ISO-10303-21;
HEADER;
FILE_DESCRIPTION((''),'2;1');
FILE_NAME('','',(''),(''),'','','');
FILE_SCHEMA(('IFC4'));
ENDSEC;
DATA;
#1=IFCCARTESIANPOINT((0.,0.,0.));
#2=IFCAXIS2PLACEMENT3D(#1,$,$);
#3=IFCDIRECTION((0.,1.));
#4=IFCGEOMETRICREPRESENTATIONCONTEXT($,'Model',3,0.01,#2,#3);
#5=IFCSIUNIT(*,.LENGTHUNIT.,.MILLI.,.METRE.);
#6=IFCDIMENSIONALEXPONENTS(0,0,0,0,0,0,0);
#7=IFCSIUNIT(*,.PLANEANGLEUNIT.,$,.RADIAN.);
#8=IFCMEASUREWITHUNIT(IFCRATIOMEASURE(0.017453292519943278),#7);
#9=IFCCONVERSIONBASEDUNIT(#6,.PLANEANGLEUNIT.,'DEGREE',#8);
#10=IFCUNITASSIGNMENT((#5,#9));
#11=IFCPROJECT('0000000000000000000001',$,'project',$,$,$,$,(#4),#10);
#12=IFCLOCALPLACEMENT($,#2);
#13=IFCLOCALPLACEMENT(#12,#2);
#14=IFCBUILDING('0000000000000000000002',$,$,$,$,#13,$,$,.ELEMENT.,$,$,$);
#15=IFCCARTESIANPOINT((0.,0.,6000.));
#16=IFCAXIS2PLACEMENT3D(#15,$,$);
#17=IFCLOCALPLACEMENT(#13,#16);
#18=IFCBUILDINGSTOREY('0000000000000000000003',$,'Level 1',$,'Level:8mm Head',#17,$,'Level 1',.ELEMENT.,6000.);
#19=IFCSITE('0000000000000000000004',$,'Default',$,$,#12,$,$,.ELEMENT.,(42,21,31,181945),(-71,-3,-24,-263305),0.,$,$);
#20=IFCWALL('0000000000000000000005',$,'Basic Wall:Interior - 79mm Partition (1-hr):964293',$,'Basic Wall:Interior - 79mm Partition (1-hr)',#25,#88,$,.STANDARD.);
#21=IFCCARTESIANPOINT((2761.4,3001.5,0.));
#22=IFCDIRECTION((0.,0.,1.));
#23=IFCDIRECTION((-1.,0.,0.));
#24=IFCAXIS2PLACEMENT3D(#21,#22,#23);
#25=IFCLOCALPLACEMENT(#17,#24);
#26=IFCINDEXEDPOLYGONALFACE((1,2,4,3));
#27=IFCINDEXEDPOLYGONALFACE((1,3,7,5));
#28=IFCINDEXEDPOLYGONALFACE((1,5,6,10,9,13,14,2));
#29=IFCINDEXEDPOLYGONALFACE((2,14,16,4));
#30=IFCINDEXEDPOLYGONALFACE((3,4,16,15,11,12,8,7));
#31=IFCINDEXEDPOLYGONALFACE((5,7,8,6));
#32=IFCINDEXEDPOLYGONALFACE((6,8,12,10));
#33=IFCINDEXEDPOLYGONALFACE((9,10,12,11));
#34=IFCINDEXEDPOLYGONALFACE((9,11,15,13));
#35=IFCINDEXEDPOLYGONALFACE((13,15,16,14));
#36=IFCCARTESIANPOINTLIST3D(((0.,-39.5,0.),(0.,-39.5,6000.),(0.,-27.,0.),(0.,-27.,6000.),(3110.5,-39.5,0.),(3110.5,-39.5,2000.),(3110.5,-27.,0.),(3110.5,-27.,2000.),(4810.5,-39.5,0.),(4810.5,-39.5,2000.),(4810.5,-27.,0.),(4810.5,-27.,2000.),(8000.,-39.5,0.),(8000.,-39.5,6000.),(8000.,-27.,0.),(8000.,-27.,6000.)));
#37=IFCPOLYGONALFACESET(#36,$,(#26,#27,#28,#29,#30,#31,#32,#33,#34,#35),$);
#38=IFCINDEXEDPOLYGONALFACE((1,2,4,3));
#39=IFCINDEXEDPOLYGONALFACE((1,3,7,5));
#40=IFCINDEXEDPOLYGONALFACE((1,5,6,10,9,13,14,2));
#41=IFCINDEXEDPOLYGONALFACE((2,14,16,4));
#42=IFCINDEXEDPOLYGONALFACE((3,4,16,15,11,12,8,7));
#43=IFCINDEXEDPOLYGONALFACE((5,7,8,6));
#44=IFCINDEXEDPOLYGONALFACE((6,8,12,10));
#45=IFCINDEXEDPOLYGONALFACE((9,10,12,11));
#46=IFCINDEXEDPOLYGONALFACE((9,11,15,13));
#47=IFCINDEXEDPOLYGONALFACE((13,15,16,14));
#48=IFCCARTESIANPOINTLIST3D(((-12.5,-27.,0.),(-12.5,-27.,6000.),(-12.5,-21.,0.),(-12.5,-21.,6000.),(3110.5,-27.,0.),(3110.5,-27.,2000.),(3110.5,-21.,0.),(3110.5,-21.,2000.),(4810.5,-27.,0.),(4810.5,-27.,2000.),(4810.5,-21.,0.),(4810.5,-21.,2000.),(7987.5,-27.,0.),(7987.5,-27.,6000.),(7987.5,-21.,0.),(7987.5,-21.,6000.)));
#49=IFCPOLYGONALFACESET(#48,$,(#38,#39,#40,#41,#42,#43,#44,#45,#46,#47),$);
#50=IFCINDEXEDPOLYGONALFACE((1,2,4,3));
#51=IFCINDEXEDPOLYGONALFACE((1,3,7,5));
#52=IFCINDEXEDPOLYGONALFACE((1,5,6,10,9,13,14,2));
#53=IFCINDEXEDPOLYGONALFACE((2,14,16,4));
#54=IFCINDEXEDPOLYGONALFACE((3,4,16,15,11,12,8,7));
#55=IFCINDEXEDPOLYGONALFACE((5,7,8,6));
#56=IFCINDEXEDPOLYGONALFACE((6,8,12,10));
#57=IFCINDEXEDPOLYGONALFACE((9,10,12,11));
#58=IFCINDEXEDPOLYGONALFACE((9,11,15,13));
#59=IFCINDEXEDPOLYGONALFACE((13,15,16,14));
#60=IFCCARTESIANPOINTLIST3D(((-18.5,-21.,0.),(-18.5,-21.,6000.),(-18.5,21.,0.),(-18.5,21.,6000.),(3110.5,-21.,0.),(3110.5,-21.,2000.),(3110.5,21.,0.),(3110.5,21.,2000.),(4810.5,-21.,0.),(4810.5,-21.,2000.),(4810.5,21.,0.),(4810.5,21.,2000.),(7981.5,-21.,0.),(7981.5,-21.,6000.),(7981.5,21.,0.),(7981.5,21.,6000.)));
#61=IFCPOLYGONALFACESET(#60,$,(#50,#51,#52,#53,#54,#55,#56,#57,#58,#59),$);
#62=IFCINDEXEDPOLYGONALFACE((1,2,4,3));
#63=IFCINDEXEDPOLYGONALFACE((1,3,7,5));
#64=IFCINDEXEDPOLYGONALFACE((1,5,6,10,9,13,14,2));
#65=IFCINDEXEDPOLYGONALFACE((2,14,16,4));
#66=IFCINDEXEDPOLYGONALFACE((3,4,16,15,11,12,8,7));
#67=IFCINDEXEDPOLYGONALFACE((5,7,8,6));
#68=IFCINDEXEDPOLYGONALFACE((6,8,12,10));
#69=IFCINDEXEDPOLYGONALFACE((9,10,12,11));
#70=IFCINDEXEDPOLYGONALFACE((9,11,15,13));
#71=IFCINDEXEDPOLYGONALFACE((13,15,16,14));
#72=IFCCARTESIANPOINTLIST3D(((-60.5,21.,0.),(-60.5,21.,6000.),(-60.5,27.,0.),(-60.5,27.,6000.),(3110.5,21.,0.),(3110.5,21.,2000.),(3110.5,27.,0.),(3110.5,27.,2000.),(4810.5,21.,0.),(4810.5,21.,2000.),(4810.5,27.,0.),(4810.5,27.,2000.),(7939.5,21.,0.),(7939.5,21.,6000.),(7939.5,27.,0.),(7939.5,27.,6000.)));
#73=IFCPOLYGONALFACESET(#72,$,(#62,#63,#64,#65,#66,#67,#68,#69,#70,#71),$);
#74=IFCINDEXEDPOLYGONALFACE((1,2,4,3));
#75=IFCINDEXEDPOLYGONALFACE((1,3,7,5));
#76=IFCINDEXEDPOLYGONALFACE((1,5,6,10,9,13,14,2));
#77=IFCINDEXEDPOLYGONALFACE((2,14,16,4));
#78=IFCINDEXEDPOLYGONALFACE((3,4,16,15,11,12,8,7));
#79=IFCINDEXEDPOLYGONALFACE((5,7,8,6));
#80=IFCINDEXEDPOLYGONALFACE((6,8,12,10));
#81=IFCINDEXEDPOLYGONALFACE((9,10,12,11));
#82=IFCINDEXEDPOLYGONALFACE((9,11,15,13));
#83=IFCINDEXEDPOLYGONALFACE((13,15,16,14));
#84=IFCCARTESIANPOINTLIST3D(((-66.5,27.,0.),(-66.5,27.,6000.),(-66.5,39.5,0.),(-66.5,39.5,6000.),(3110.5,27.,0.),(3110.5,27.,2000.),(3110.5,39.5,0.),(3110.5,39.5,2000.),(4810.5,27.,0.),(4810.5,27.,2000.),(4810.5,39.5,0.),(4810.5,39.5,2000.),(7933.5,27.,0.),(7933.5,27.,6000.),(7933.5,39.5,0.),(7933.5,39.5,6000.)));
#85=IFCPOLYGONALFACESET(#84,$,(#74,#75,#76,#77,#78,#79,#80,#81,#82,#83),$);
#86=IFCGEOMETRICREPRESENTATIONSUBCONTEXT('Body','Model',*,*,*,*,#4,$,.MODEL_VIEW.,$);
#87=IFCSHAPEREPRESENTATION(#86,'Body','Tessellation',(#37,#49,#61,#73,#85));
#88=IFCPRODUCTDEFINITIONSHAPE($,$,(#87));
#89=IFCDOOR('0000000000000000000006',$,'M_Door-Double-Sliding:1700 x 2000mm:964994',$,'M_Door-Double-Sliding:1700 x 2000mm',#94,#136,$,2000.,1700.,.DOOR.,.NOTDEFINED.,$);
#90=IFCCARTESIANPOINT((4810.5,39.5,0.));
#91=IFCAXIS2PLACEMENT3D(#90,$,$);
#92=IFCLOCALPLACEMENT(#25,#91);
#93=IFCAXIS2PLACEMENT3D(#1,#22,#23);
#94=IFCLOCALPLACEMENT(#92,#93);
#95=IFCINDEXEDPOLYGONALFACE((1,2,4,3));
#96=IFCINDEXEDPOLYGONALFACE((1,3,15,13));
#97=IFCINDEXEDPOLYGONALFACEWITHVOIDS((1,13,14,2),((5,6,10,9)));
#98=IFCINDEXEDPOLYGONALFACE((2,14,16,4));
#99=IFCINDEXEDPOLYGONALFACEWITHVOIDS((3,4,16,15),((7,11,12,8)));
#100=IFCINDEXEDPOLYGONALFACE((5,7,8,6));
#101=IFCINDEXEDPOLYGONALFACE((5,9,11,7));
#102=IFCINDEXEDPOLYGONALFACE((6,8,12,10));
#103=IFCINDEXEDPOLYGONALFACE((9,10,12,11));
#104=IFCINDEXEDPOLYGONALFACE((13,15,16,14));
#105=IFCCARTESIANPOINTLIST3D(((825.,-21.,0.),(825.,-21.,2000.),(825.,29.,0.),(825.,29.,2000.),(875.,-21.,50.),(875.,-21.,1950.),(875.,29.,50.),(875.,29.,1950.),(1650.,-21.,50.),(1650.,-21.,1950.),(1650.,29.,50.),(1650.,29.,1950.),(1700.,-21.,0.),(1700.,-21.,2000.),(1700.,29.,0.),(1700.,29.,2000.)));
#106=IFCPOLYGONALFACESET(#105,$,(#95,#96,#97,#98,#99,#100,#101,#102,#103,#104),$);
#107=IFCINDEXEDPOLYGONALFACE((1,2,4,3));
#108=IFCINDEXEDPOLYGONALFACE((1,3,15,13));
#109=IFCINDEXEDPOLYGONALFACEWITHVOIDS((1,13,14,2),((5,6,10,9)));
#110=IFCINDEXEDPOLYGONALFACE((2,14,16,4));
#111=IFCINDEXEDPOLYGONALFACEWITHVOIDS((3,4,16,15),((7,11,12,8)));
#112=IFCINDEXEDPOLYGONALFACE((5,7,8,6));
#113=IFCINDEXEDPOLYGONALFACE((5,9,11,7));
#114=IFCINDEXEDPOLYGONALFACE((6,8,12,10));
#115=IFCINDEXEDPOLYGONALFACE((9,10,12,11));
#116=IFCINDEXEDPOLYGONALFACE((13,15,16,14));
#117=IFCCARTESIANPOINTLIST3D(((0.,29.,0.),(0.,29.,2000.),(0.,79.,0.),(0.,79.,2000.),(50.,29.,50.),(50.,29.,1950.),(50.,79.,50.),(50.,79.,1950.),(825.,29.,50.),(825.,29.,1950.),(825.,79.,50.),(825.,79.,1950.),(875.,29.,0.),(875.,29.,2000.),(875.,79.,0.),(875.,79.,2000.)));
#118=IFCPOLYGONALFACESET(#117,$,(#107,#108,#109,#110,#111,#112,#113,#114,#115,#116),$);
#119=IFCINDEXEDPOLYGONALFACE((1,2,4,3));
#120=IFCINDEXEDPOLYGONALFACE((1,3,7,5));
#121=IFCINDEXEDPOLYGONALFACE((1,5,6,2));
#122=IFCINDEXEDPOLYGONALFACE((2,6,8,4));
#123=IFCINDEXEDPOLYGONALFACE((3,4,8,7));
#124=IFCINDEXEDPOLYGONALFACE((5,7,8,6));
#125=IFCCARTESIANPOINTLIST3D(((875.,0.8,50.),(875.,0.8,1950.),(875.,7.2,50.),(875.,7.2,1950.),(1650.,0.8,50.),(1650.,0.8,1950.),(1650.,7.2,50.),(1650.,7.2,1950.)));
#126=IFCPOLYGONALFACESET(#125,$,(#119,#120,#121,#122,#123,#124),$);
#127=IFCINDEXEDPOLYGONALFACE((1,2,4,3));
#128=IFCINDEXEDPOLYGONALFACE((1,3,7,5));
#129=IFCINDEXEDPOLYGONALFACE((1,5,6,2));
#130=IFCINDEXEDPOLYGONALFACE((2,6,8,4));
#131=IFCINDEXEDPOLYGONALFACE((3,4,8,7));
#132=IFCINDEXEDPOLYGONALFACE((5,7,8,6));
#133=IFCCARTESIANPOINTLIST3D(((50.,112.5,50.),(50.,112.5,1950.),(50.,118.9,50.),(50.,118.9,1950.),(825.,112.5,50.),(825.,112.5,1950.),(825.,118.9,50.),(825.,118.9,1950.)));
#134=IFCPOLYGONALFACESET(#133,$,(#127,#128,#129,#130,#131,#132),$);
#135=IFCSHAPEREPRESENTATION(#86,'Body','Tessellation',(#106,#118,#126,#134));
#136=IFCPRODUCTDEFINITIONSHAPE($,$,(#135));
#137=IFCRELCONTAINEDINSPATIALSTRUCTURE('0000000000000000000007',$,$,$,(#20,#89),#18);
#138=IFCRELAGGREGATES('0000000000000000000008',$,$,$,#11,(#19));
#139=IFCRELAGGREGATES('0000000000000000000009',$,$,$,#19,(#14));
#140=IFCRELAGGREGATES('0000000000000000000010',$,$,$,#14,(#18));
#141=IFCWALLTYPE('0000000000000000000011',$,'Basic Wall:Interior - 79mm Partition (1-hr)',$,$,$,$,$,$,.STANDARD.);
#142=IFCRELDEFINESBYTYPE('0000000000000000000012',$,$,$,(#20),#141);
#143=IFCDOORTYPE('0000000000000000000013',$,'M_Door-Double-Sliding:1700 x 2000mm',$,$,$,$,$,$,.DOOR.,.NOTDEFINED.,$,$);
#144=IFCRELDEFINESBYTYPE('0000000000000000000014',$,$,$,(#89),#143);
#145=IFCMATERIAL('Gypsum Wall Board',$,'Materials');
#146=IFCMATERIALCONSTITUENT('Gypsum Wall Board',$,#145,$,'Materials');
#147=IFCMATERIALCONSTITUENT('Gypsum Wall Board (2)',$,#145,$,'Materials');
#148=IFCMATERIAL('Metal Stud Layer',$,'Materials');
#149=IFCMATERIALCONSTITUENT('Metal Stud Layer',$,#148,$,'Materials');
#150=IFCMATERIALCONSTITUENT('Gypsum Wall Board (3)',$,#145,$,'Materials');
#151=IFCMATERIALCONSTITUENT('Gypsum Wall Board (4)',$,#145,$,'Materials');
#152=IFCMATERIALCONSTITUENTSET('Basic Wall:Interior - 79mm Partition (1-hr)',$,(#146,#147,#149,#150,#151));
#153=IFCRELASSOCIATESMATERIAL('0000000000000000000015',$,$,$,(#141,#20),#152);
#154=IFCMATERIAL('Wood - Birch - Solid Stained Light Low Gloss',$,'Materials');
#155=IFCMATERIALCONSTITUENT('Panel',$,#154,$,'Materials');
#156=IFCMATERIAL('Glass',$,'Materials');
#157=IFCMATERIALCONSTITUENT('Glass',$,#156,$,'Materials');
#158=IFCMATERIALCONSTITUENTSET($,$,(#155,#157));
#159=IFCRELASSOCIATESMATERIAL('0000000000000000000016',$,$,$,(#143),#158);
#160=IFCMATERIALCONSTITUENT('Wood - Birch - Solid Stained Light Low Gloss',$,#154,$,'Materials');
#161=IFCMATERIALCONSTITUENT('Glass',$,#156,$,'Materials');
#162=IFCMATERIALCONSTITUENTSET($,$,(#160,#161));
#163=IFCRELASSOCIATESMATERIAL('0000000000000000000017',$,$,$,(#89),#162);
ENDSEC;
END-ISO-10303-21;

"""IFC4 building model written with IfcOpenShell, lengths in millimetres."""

from ifc_helpers import new_model, entity, si_unit, converted_unit, direction, frame, origin, place, context, subcontext, project, spatial, indexed_curve, outline, extrude, source, transform, mapped, material, constituent, constituent_set, type_object, type_shapes, element, fill, save


model = new_model("IFC4")

# Units and contexts
model_context = context("Model", 3, precision=0.01, world=origin(), true_north=direction((0.0, 1.0)))
body_context = subcontext(model_context, "Body", "Model", "MODEL_VIEW")
ifc_project = project(units=[si_unit("LENGTHUNIT", "METRE", prefix="MILLI"), converted_unit("PLANEANGLEUNIT", "DEGREE", entity("IfcRatioMeasure", 0.017453292519943278), si_unit("PLANEANGLEUNIT", "RADIAN"), dimensions=[0, 0, 0, 0, 0, 0, 0])], contexts=[model_context])

# Site, building, storey
site_placement = place(None, origin())
site = spatial("IfcSite", under=ifc_project, at=site_placement, Name="Default", CompositionType="ELEMENT", RefLatitude=(42, 21, 31, 181945), RefLongitude=(-71, -3, -24, -263305), RefElevation=0.0)
building_placement = place(site_placement, origin())
building = spatial("IfcBuilding", under=site, at=building_placement, CompositionType="ELEMENT")
storey_placement = place(building_placement, frame((0.0, 0.0, 6000.0)))
storey = spatial("IfcBuildingStorey", under=building, at=storey_placement, Name="Level 1", ObjectType="Level:8mm Head", LongName="Level 1", CompositionType="ELEMENT", Elevation=6000.0)

# Shared definitions
ifc_material_1 = material(Name="Gypsum Wall Board", Category="Materials")
ifc_constituent_1 = constituent(ifc_material_1, Name="Gypsum Wall Board", Category="Materials")
ifc_constituent_2 = constituent(ifc_material_1, Name="Gypsum Wall Board (2)", Category="Materials")
ifc_material_2 = material(Name="Metal Stud Layer", Category="Materials")
ifc_constituent_3 = constituent(ifc_material_2, Name="Metal Stud Layer", Category="Materials")
ifc_constituent_4 = constituent(ifc_material_1, Name="Gypsum Wall Board (3)", Category="Materials")
ifc_constituent_5 = constituent(ifc_material_1, Name="Gypsum Wall Board (4)", Category="Materials")
ifc_constituent_set_1 = constituent_set(constituents=[ifc_constituent_1, ifc_constituent_2, ifc_constituent_3, ifc_constituent_4, ifc_constituent_5], Name="Basic Wall:Interior - 79mm Partition (1-hr)")
wall_type = type_object("IfcWallType", Name="Basic Wall:Interior - 79mm Partition (1-hr)", PredefinedType="STANDARD", material=ifc_constituent_set_1)

# Wall, opening, door
wall_1_placement = place(storey_placement, frame((2761.4, 3001.5, 0.0), z_axis=(0.0, 0.0, 1.0), x_axis=(-1.0, 0.0, 0.0)))
wall_1 = element("IfcWall", 1, at=wall_1_placement, inside=storey, type_object=wall_type, material=ifc_constituent_set_1, Name="Basic Wall:Interior - 79mm Partition (1-hr):964293", ObjectType="Basic Wall:Interior - 79mm Partition (1-hr)", PredefinedType="STANDARD", context=body_context, shape_type="SweptSolid", body=[
    extrude(outline(indexed_curve([(-2000.0, -869.8), (-2000.0, -3980.3), (4000.0, -3980.3), (4000.0, 4019.8), (-2000.0, 4019.8), (-2000.0, 830.2), (0.0, 830.2), (0.0, -869.8), (-2000.0, -869.8)], self_intersect=False)), frame((3980.3, -27.0, 2000.0), z_axis=(0.0, 1.0, 0.0), x_axis=(0.0, 0.0, 1.0)), (0.0, 0.0, -1.0), 12.5),
    extrude(outline(indexed_curve([(-2000.0, -863.5), (-2000.0, -3986.5), (4000.0, -3986.5), (4000.0, 4013.5), (-2000.0, 4013.5), (-2000.0, 836.5), (0.0, 836.5), (0.0, -863.5), (-2000.0, -863.5)], self_intersect=False)), frame((3974.0, -21.0, 2000.0), z_axis=(0.0, 1.0, 0.0), x_axis=(0.0, 0.0, 1.0)), (0.0, 0.0, -1.0), 6.0),
    extrude(outline(indexed_curve([(-2000.0, -860.5), (-2000.0, -3989.5), (4000.0, -3989.5), (4000.0, 4010.5), (-2000.0, 4010.5), (-2000.0, 839.5), (0.0, 839.5), (0.0, -860.5), (-2000.0, -860.5)], self_intersect=False)), frame((3971.0, 21.0, 2000.0), z_axis=(0.0, 1.0, 0.0), x_axis=(0.0, 0.0, 1.0)), (0.0, 0.0, -1.0), 42.0),
    extrude(outline(indexed_curve([(-2000.0, -839.5), (-2000.0, -4010.5), (4000.0, -4010.5), (4000.0, 3989.5), (-2000.0, 3989.5), (-2000.0, 860.5), (0.0, 860.5), (0.0, -839.5), (-2000.0, -839.5)], self_intersect=False)), frame((3950.0, 27.0, 2000.0), z_axis=(0.0, 1.0, 0.0), x_axis=(0.0, 0.0, 1.0)), (0.0, 0.0, -1.0), 6.0),
    extrude(outline(indexed_curve([(-1631.3, 200.0), (-1631.3, 2200.0), (-4808.3, 2200.0), (-4808.3, -3800.0), (3179.2, -3800.0), (3191.7, -3800.0), (3191.7, 2200.0), (3179.2, 2200.0), (68.7, 2200.0), (68.7, 200.0), (-1631.3, 200.0)], self_intersect=False)), frame((4741.8, 39.5, 2200.0), z_axis=(0.0, 1.0, 0.0), x_axis=(1.0, 0.0, 0.0)), (0.0, 0.0, -1.0), 12.5),
])
opening_1_placement = place(wall_1_placement, frame((4810.5, 39.5, 0.0)))
opening_1 = element("IfcOpeningElement", 2, at=opening_1_placement, cuts=wall_1, PredefinedType="OPENING", context=body_context, shape_type="SweptSolid", body=[
    extrude(outline(indexed_curve([(2000.0, 0.0), (2000.0, 1700.0), (0.0, 1700.0), (0.0, 0.0), (2000.0, 0.0)], self_intersect=False)), frame((0.0, 0.0, 0.0), z_axis=(0.0, -1.0, 0.0), x_axis=(0.0, 0.0, 1.0)), (0.0, 0.0, 1.0), 79.0),
])
ifc_material_3 = material(Name="Wood - Birch - Solid Stained Light Low Gloss", Category="Materials")
ifc_constituent_6 = constituent(ifc_material_3, Name="Wood - Birch - Solid Stained Light Low Gloss", Category="Materials")
ifc_material_4 = material(Name="Glass", Category="Materials")
ifc_constituent_7 = constituent(ifc_material_4, Name="Glass", Category="Materials")
ifc_constituent_set_2 = constituent_set(constituents=[ifc_constituent_6, ifc_constituent_7])
ifc_constituent_8 = constituent(ifc_material_3, Name="Panel", Category="Materials")
ifc_constituent_9 = constituent(ifc_material_4, Name="Glass", Category="Materials")
ifc_constituent_set_3 = constituent_set(constituents=[ifc_constituent_8, ifc_constituent_9])
door_type = type_object("IfcDoorType", Name="M_Door-Double-Sliding:1700 x 2000mm", OperationType="NOTDEFINED", PredefinedType="DOOR", material=ifc_constituent_set_3)
shared_shape_1 = source(origin(), body_context, "Body", "SweptSolid", [
    extrude(outline(indexed_curve([(-437.5, -1000.0), (437.5, -1000.0), (437.5, 1000.0), (-437.5, 1000.0), (-437.5, -1000.0)], self_intersect=False), holes=[indexed_curve([(-387.5, -950.0), (-387.5, 950.0), (387.5, 950.0), (387.5, -950.0), (-387.5, -950.0)], self_intersect=False)]), frame((1262.5, -21.0, 1000.0), z_axis=(0.0, 1.0, 0.0), x_axis=(1.0, 0.0, 0.0)), (0.0, 0.0, 1.0), 50.0),
    extrude(outline(indexed_curve([(-1000.0, -437.5), (1000.0, -437.5), (1000.0, 437.5), (-1000.0, 437.5), (-1000.0, -437.5)], self_intersect=False), holes=[indexed_curve([(-950.0, -387.5), (-950.0, 387.5), (950.0, 387.5), (950.0, -387.5), (-950.0, -387.5)], self_intersect=False)]), frame((437.5, 29.0, 1000.0), z_axis=(0.0, 1.0, 0.0), x_axis=(0.0, 0.0, -1.0)), (0.0, 0.0, 1.0), 50.0),
    extrude(outline(indexed_curve([(-3.2, -387.5), (3.2, -387.5), (3.2, 387.5), (-3.2, 387.5), (-3.2, -387.5)], self_intersect=False)), frame((1262.5, 4.0, 50.0), z_axis=(0.0, 0.0, 1.0), x_axis=(0.0, -1.0, 0.0)), (0.0, 0.0, 1.0), 1900.0),
    extrude(outline(indexed_curve([(-3.2, -387.5), (3.2, -387.5), (3.2, 387.5), (-3.2, 387.5), (-3.2, -387.5)], self_intersect=False)), frame((437.5, 115.7, 50.0), z_axis=(0.0, 0.0, 1.0), x_axis=(0.0, 1.0, 0.0)), (0.0, 0.0, 1.0), 1900.0),
])
type_shapes(door_type, [shared_shape_1])
door_1_placement = place(opening_1_placement, frame((0.0, 0.0, 0.0), z_axis=(0.0, 0.0, 1.0), x_axis=(-1.0, 0.0, 0.0)))
door_1 = element("IfcDoor", 3, at=door_1_placement, inside=storey, type_object=door_type, material=ifc_constituent_set_2, Name="M_Door-Double-Sliding:1700 x 2000mm:964994", ObjectType="M_Door-Double-Sliding:1700 x 2000mm", OperationType="NOTDEFINED", OverallHeight=2000.0, OverallWidth=1700.0, PredefinedType="DOOR", context=body_context, shape_type="MappedRepresentation", body=[
    mapped(shared_shape_1, transform((0.0, 0.0, 0.0), scale=1.0)),
])
fill(opening_1, door_1)

save(model, "model.ifc")
